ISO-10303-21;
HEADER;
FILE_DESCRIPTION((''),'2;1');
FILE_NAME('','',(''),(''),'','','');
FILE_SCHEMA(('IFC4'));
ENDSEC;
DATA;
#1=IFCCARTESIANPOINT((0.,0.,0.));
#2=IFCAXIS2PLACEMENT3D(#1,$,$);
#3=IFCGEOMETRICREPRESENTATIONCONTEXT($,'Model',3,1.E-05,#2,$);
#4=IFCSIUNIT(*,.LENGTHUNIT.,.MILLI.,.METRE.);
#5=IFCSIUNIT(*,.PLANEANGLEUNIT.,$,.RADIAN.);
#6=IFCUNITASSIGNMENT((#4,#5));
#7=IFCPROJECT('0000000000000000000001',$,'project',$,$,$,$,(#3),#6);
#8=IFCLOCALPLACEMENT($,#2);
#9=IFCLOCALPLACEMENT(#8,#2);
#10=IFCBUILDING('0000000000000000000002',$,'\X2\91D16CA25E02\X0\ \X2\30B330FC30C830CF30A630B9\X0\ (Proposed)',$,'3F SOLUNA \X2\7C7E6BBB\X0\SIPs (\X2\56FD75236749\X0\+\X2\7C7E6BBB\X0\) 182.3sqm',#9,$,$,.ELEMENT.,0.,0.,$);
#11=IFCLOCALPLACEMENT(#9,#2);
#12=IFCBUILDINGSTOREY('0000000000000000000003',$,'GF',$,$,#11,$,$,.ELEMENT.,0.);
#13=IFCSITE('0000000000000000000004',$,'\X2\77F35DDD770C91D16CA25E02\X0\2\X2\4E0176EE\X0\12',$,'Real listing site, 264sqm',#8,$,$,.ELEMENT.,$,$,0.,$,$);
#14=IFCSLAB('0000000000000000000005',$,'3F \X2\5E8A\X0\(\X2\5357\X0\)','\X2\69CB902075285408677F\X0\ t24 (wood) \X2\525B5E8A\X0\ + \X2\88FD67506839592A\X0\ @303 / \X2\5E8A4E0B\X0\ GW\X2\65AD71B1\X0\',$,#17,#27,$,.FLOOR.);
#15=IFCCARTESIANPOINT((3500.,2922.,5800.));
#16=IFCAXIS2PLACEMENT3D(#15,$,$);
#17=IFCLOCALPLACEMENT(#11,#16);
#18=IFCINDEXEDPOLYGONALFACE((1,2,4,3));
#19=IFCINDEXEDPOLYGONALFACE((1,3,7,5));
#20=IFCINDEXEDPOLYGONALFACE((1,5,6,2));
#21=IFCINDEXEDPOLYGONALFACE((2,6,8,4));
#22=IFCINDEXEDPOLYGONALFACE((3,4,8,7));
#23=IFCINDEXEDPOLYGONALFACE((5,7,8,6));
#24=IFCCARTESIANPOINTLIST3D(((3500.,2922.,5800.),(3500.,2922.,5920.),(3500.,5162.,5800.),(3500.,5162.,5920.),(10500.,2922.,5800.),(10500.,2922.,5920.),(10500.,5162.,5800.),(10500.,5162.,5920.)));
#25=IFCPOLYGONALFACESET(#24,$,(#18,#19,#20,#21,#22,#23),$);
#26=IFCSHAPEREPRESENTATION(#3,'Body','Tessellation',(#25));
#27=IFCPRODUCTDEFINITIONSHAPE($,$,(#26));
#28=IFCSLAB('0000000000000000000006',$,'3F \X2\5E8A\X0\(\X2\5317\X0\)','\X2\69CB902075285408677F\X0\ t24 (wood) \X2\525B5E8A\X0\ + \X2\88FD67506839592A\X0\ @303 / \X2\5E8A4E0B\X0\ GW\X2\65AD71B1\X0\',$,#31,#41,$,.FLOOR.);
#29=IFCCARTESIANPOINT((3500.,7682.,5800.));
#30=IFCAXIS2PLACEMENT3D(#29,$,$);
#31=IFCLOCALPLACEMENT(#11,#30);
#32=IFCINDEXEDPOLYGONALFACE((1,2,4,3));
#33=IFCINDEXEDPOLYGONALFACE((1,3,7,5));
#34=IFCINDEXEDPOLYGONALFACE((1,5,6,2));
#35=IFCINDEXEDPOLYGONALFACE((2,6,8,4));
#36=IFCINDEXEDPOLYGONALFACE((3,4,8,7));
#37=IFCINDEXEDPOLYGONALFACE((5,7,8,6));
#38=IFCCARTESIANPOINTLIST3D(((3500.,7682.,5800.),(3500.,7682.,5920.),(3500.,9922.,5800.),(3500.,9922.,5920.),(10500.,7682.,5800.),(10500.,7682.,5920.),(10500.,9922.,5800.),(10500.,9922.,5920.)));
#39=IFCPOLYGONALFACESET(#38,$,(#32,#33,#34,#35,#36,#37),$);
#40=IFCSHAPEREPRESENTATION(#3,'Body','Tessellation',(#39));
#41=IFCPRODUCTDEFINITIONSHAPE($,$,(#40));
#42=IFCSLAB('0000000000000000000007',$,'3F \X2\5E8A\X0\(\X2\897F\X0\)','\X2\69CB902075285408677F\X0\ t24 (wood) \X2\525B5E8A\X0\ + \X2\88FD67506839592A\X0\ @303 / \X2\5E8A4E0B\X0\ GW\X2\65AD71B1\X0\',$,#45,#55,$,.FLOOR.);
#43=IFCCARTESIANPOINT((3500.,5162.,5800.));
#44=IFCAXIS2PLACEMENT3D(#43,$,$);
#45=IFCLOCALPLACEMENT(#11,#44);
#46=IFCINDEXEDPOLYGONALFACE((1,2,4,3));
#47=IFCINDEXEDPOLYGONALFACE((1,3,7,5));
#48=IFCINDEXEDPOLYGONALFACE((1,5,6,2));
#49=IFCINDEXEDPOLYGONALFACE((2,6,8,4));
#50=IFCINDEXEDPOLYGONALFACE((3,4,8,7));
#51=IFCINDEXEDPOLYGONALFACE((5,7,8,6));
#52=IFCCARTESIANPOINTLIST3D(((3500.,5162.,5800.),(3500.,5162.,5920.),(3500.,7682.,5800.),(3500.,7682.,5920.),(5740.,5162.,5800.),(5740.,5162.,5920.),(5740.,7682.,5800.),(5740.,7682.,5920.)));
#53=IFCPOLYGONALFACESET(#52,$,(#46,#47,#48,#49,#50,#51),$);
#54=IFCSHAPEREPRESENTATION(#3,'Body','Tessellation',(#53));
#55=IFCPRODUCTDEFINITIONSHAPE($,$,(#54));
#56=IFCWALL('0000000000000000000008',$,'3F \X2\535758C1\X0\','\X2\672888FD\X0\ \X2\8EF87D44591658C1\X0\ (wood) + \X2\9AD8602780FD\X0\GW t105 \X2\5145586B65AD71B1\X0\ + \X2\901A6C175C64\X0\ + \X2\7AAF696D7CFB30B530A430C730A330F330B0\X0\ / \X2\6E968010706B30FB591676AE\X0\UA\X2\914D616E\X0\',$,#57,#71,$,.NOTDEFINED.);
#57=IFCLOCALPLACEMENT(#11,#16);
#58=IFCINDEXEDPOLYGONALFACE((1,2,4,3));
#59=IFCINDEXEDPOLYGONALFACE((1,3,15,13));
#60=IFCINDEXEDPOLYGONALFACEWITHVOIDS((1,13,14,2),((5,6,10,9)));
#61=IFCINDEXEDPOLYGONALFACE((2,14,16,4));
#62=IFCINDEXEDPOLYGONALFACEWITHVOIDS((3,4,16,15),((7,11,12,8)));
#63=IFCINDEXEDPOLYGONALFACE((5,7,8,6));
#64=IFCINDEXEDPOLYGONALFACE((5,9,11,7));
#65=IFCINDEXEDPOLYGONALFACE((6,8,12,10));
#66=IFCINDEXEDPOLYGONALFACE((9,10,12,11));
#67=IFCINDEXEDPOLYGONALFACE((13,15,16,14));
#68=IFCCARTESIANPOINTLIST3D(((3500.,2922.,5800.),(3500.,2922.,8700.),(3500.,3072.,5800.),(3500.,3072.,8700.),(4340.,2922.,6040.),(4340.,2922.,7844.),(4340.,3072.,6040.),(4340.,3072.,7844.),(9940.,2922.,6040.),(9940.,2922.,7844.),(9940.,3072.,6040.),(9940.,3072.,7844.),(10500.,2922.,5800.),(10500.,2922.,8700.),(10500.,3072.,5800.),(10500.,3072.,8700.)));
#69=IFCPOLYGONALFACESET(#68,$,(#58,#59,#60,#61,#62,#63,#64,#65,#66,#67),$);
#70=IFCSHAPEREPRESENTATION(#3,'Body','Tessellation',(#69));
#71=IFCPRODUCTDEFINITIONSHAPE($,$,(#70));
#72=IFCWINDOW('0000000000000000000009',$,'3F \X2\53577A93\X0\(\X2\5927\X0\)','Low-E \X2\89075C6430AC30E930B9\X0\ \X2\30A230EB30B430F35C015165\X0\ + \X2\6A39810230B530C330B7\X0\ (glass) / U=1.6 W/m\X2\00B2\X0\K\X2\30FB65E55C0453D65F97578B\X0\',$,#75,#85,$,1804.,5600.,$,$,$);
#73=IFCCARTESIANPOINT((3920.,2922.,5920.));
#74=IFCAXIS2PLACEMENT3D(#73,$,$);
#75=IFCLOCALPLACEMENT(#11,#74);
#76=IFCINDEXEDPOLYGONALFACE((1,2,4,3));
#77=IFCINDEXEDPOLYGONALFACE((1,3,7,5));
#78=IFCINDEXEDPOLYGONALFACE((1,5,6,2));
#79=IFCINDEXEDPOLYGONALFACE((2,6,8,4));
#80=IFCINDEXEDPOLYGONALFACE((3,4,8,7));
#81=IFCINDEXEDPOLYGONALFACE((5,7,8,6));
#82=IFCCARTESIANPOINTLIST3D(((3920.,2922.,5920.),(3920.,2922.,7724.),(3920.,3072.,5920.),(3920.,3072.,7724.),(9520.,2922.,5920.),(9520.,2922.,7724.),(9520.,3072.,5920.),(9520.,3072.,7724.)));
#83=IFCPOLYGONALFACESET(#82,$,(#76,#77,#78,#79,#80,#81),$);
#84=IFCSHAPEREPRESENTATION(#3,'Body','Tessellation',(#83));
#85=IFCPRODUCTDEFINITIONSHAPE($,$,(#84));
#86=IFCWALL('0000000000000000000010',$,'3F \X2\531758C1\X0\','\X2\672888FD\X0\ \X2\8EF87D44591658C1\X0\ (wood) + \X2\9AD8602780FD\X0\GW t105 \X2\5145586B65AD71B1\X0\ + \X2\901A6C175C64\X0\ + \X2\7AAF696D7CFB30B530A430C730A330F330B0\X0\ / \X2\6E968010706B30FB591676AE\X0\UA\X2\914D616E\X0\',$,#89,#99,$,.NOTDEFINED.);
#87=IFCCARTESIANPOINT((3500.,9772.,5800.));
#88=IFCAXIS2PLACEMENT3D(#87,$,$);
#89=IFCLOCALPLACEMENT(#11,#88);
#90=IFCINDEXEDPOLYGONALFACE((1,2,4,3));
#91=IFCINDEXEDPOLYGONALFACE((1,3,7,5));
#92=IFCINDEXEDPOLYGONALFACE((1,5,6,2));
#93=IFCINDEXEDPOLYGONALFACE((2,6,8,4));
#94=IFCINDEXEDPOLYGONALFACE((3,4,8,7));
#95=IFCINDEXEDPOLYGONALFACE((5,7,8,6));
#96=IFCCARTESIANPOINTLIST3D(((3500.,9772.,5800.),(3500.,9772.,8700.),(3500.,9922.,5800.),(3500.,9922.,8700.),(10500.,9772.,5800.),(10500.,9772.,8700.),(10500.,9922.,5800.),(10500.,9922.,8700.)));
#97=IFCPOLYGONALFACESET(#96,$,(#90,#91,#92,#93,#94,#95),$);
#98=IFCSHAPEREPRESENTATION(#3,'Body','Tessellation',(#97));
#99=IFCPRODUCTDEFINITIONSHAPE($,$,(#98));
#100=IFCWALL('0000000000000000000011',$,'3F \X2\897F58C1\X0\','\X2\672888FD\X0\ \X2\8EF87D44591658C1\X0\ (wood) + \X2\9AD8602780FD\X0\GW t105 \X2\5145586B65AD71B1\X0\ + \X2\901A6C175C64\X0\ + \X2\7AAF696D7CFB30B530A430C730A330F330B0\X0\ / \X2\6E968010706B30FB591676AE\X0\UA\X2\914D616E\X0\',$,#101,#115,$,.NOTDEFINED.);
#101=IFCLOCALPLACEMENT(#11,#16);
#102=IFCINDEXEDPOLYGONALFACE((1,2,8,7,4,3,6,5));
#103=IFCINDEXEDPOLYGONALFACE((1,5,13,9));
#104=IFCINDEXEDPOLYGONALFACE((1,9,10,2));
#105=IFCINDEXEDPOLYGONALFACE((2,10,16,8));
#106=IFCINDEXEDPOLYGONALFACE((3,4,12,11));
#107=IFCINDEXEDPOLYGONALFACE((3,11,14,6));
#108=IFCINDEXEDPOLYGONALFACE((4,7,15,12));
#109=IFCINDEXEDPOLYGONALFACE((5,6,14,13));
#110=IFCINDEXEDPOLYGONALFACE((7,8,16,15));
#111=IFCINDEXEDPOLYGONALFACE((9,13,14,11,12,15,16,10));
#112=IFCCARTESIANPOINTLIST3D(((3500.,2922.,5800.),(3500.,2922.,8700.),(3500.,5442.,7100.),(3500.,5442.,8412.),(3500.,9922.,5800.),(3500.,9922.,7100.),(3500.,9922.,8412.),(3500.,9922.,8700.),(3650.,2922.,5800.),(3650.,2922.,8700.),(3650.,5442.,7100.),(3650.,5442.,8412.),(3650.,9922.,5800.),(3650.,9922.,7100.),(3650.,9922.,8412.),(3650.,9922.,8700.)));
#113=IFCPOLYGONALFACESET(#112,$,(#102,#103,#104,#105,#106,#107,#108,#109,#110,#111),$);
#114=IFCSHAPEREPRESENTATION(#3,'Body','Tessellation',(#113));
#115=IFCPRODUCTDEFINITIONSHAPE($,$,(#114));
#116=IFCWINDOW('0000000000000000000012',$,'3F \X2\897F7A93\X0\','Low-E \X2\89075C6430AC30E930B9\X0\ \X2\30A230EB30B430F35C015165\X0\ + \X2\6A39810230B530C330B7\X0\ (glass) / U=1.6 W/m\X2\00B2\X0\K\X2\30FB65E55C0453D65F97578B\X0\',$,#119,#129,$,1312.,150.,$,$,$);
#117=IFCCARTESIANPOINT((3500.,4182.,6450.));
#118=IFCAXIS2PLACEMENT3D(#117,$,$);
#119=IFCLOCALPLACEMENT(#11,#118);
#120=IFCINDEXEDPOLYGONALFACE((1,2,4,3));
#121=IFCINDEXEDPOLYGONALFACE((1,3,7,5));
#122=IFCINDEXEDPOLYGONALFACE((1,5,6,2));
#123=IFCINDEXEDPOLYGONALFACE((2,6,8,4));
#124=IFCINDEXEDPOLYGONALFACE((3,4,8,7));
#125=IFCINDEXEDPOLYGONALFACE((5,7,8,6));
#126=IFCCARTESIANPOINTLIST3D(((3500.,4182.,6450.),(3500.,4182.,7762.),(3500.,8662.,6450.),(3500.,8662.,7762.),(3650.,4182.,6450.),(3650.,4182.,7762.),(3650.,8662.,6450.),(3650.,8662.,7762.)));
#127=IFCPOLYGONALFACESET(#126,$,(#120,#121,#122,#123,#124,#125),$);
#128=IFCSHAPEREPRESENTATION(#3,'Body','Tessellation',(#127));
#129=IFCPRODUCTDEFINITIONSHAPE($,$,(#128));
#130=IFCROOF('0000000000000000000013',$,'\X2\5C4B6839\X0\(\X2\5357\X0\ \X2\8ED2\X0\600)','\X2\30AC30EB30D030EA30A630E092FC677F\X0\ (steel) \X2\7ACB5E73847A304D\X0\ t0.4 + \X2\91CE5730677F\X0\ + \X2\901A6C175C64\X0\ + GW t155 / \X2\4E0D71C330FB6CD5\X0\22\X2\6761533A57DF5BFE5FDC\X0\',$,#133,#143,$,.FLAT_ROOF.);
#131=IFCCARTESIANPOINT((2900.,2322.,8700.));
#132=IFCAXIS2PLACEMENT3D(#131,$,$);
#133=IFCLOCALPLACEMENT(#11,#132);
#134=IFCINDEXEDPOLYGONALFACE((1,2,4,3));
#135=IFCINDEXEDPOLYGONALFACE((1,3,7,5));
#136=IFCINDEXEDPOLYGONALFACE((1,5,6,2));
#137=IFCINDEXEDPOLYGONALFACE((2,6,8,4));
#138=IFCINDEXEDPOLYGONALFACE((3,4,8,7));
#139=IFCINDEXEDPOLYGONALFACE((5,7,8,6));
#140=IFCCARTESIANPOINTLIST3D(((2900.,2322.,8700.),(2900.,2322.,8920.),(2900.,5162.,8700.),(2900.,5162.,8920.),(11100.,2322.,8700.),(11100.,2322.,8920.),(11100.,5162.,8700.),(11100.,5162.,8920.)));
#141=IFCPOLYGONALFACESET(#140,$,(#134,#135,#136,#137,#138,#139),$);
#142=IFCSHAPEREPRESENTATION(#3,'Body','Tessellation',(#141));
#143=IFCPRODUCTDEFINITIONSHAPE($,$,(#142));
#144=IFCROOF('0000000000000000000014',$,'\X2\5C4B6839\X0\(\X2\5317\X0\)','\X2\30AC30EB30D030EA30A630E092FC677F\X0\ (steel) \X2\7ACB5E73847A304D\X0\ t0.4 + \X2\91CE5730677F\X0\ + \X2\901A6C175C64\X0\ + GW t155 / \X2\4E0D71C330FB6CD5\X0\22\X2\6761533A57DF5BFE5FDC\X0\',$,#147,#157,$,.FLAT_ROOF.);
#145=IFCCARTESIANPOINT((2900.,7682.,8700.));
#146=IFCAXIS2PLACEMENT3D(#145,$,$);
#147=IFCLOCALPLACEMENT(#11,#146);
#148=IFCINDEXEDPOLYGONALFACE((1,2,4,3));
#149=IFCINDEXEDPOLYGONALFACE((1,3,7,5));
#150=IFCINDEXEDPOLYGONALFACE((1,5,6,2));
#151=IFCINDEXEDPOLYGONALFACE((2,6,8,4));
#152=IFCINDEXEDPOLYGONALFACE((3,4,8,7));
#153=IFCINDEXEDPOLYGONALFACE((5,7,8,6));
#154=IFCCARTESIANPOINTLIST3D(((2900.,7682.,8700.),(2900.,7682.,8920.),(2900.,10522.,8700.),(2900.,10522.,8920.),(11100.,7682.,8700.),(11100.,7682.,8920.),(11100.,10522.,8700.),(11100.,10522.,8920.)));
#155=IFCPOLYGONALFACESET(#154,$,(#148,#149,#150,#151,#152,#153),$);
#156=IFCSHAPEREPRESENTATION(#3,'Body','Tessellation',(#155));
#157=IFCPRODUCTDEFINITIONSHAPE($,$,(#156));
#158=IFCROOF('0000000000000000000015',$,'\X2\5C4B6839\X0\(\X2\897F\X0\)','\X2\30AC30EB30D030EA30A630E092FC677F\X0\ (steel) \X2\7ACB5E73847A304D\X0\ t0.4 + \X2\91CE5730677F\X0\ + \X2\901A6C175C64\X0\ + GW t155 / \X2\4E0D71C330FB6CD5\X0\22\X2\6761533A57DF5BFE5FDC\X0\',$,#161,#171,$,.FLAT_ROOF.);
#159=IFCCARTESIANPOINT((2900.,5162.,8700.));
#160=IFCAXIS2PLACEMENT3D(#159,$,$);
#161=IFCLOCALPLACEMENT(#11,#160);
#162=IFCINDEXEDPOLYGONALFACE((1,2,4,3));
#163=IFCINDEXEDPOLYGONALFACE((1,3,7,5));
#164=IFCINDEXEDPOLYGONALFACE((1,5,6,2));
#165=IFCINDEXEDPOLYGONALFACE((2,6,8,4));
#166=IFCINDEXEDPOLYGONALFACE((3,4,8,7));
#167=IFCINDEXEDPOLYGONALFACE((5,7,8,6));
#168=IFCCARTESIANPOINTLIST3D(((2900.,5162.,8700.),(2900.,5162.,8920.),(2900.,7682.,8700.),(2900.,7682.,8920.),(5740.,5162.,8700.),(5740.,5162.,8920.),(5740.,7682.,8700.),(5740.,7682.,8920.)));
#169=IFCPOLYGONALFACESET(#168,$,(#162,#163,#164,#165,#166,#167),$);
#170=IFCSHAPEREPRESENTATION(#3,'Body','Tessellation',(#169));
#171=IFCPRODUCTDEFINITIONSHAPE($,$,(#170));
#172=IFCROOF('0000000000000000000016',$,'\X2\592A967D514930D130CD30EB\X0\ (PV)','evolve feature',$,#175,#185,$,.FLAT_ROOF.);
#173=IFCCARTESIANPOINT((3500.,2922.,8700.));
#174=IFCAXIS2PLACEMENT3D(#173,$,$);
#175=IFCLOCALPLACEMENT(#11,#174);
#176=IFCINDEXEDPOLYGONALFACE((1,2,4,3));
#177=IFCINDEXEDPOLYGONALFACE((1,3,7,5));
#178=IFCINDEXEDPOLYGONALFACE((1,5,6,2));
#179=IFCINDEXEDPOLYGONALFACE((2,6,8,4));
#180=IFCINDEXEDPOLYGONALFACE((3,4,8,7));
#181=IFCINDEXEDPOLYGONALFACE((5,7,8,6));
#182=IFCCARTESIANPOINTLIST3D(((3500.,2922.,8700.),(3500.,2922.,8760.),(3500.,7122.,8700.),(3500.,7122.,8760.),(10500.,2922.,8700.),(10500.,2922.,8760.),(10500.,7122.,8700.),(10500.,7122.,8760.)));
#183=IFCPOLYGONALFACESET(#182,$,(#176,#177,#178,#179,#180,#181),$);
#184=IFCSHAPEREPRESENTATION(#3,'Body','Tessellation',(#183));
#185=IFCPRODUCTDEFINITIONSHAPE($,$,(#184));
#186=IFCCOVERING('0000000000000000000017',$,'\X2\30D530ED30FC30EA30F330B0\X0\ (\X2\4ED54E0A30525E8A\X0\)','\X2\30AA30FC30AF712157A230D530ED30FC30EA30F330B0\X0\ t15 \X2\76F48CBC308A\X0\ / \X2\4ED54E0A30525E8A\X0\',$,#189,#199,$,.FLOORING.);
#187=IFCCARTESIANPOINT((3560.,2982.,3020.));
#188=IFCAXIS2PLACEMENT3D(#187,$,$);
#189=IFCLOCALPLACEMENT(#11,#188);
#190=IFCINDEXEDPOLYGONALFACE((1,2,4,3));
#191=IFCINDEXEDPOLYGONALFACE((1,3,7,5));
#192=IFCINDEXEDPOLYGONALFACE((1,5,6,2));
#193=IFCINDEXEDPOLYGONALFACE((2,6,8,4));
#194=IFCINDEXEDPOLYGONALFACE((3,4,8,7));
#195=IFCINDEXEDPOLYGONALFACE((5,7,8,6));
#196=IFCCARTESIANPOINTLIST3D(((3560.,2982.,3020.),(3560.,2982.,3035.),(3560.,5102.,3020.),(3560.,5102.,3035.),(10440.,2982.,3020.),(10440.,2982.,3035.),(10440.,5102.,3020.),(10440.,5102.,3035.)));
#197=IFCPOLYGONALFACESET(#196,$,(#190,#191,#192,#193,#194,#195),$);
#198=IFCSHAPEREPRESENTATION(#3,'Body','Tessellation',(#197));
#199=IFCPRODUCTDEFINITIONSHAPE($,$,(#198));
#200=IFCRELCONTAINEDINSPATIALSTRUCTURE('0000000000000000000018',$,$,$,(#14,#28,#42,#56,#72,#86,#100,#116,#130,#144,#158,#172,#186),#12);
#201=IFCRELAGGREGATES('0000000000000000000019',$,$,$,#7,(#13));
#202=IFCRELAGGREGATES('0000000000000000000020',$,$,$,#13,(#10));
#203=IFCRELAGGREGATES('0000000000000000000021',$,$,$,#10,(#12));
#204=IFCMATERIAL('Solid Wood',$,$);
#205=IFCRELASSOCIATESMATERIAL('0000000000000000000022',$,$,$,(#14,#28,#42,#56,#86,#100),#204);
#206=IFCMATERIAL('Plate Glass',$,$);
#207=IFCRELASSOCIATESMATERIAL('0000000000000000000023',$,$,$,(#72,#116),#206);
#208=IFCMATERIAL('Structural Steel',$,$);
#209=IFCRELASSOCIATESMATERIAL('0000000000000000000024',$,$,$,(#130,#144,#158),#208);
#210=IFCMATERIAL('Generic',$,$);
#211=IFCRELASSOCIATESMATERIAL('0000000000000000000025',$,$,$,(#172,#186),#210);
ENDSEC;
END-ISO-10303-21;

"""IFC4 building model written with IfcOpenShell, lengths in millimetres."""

from ifc_helpers import new_model, si_unit, frame, frame_2d, origin, place, context, project, spatial, rectangle, extrude, material, element, fill, save


model = new_model("IFC4")

# Units and contexts
model_context = context("Model", 3, precision=1e-05, world=origin())
ifc_project = project(units=[si_unit("LENGTHUNIT", "METRE", prefix="MILLI"), si_unit("PLANEANGLEUNIT", "RADIAN")], contexts=[model_context])

# Site, building, storey
site_placement = place(None, origin())
site = spatial("IfcSite", under=ifc_project, at=site_placement, Name="石川県金沢市2丁目12", ObjectType="Real listing site, 264sqm", CompositionType="ELEMENT", RefElevation=0.0)
building_placement = place(site_placement, origin())
building = spatial("IfcBuilding", under=site, at=building_placement, Name="金沢市 コートハウス (Proposed)", ObjectType="3F SOLUNA 籾殻SIPs (国産杉+籾殻) 182.3sqm", CompositionType="ELEMENT", ElevationOfRefHeight=0.0, ElevationOfTerrain=0.0)
storey_placement = place(building_placement, origin())
storey = spatial("IfcBuildingStorey", under=building, at=storey_placement, Name="GF", CompositionType="ELEMENT", Elevation=0.0)

# Slabs
ifc_material_1 = material(Name="Solid Wood")
slab_1_placement = place(storey_placement, frame((3500.0, 2922.0, 5800.0)))
element("IfcSlab", 1, at=slab_1_placement, inside=storey, material=ifc_material_1, Name="3F 床(南)", Description="構造用合板 t24 (wood) 剛床 + 製材根太 @303 / 床下 GW断熱", PredefinedType="FLOOR", context=model_context, shape_type="SweptSolid", body=[
    extrude(rectangle(XDim=7000.0, YDim=2240.0, at=frame_2d((3500.0, 1120.0))), frame((3500.0, 2922.0, 5800.0)), (0.0, 0.0, 1.0), 120.0),
])
slab_2_placement = place(storey_placement, frame((3500.0, 7682.0, 5800.0)))
element("IfcSlab", 2, at=slab_2_placement, inside=storey, material=ifc_material_1, Name="3F 床(北)", Description="構造用合板 t24 (wood) 剛床 + 製材根太 @303 / 床下 GW断熱", PredefinedType="FLOOR", context=model_context, shape_type="SweptSolid", body=[
    extrude(rectangle(XDim=7000.0, YDim=2240.0, at=frame_2d((3500.0, 1120.0))), frame((3500.0, 7682.0, 5800.0)), (0.0, 0.0, 1.0), 120.0),
])
slab_3_placement = place(storey_placement, frame((3500.0, 5162.0, 5800.0)))
element("IfcSlab", 3, at=slab_3_placement, inside=storey, material=ifc_material_1, Name="3F 床(西)", Description="構造用合板 t24 (wood) 剛床 + 製材根太 @303 / 床下 GW断熱", PredefinedType="FLOOR", context=model_context, shape_type="SweptSolid", body=[
    extrude(rectangle(XDim=2240.0, YDim=2520.0, at=frame_2d((1120.0, 1260.0))), frame((3500.0, 5162.0, 5800.0)), (0.0, 0.0, 1.0), 120.0),
])

# Wall, opening, window
wall_1_placement = place(storey_placement, frame((3500.0, 2922.0, 5800.0)))
wall_1 = element("IfcWall", 4, at=wall_1_placement, inside=storey, material=ifc_material_1, Name="3F 南壁", Description="木製 軸組外壁 (wood) + 高性能GW t105 充填断熱 + 通気層 + 窯業系サイディング / 準耐火・外皮UA配慮", PredefinedType="NOTDEFINED", context=model_context, shape_type="SweptSolid", body=[
    extrude(rectangle(XDim=7000.0, YDim=150.0, at=frame_2d((3500.0, 75.0))), frame((3500.0, 2922.0, 5800.0)), (0.0, 0.0, 1.0), 2900.0),
])
opening_1_placement = place(storey_placement, frame((3920.0, 2922.0, 5920.0)))
opening_1 = element("IfcOpeningElement", 5, at=opening_1_placement, cuts=wall_1, PredefinedType="NOTDEFINED", context=model_context, shape_type="SweptSolid", body=[
    extrude(rectangle(XDim=5600.0, YDim=150.0, at=frame_2d((2800.0, 75.0))), frame((3920.0, 2922.0, 5920.0)), (0.0, 0.0, 1.0), 1804.0),
])
ifc_material_2 = material(Name="Plate Glass")
window_1_placement = place(storey_placement, frame((3920.0, 2922.0, 5920.0)))
window_1 = element("IfcWindow", 6, at=window_1_placement, inside=storey, material=ifc_material_2, Name="3F 南窓(大)", Description="Low-E 複層ガラス アルゴン封入 + 樹脂サッシ (glass) / U=1.6 W/m²K・日射取得型", OverallHeight=1804.0, OverallWidth=5600.0, context=model_context, shape_type="SweptSolid", body=[
    extrude(rectangle(XDim=5600.0, YDim=150.0, at=frame_2d((2800.0, 75.0))), frame((3920.0, 2922.0, 5920.0)), (0.0, 0.0, 1.0), 1804.0),
])
fill(opening_1, window_1)

# Wall
wall_2_placement = place(storey_placement, frame((3500.0, 9772.0, 5800.0)))
element("IfcWall", 7, at=wall_2_placement, inside=storey, material=ifc_material_1, Name="3F 北壁", Description="木製 軸組外壁 (wood) + 高性能GW t105 充填断熱 + 通気層 + 窯業系サイディング / 準耐火・外皮UA配慮", PredefinedType="NOTDEFINED", context=model_context, shape_type="SweptSolid", body=[
    extrude(rectangle(XDim=7000.0, YDim=150.0, at=frame_2d((3500.0, 75.0))), frame((3500.0, 9772.0, 5800.0)), (0.0, 0.0, 1.0), 2900.0),
])

# Wall, opening, window
wall_3_placement = place(storey_placement, frame((3500.0, 2922.0, 5800.0)))
wall_3 = element("IfcWall", 8, at=wall_3_placement, inside=storey, material=ifc_material_1, Name="3F 西壁", Description="木製 軸組外壁 (wood) + 高性能GW t105 充填断熱 + 通気層 + 窯業系サイディング / 準耐火・外皮UA配慮", PredefinedType="NOTDEFINED", context=model_context, shape_type="SweptSolid", body=[
    extrude(rectangle(XDim=150.0, YDim=7000.0, at=frame_2d((75.0, 3500.0))), frame((3500.0, 2922.0, 5800.0)), (0.0, 0.0, 1.0), 2900.0),
])
opening_2_placement = place(storey_placement, frame((3500.0, 4182.0, 6450.0)))
opening_2 = element("IfcOpeningElement", 9, at=opening_2_placement, cuts=wall_3, PredefinedType="NOTDEFINED", context=model_context, shape_type="SweptSolid", body=[
    extrude(rectangle(XDim=150.0, YDim=4480.0, at=frame_2d((75.0, 2240.0))), frame((3500.0, 4182.0, 6450.0)), (0.0, 0.0, 1.0), 1312.0),
])
window_2_placement = place(storey_placement, frame((3500.0, 4182.0, 6450.0)))
window_2 = element("IfcWindow", 10, at=window_2_placement, inside=storey, material=ifc_material_2, Name="3F 西窓", Description="Low-E 複層ガラス アルゴン封入 + 樹脂サッシ (glass) / U=1.6 W/m²K・日射取得型", OverallHeight=1312.0, OverallWidth=150.0, context=model_context, shape_type="SweptSolid", body=[
    extrude(rectangle(XDim=150.0, YDim=4480.0, at=frame_2d((75.0, 2240.0))), frame((3500.0, 4182.0, 6450.0)), (0.0, 0.0, 1.0), 1312.0),
])
fill(opening_2, window_2)

# Roofs
ifc_material_3 = material(Name="Structural Steel")
roof_1_placement = place(storey_placement, frame((2900.0, 2322.0, 8700.0)))
element("IfcRoof", 11, at=roof_1_placement, inside=storey, material=ifc_material_3, Name="屋根(南 軒600)", Description="ガルバリウム鋼板 (steel) 立平葺き t0.4 + 野地板 + 通気層 + GW t155 / 不燃・法22条区域対応", PredefinedType="FLAT_ROOF", context=model_context, shape_type="SweptSolid", body=[
    extrude(rectangle(XDim=8200.0, YDim=2840.0, at=frame_2d((4100.0, 1420.0))), frame((2900.0, 2322.0, 8700.0)), (0.0, 0.0, 1.0), 220.0),
])
roof_2_placement = place(storey_placement, frame((2900.0, 7682.0, 8700.0)))
element("IfcRoof", 12, at=roof_2_placement, inside=storey, material=ifc_material_3, Name="屋根(北)", Description="ガルバリウム鋼板 (steel) 立平葺き t0.4 + 野地板 + 通気層 + GW t155 / 不燃・法22条区域対応", PredefinedType="FLAT_ROOF", context=model_context, shape_type="SweptSolid", body=[
    extrude(rectangle(XDim=8200.0, YDim=2840.0, at=frame_2d((4100.0, 1420.0))), frame((2900.0, 7682.0, 8700.0)), (0.0, 0.0, 1.0), 220.0),
])
roof_3_placement = place(storey_placement, frame((2900.0, 5162.0, 8700.0)))
element("IfcRoof", 13, at=roof_3_placement, inside=storey, material=ifc_material_3, Name="屋根(西)", Description="ガルバリウム鋼板 (steel) 立平葺き t0.4 + 野地板 + 通気層 + GW t155 / 不燃・法22条区域対応", PredefinedType="FLAT_ROOF", context=model_context, shape_type="SweptSolid", body=[
    extrude(rectangle(XDim=2840.0, YDim=2520.0, at=frame_2d((1420.0, 1260.0))), frame((2900.0, 5162.0, 8700.0)), (0.0, 0.0, 1.0), 220.0),
])
ifc_material_4 = material(Name="Generic")
roof_4_placement = place(storey_placement, frame((3500.0, 2922.0, 8700.0)))
element("IfcRoof", 14, at=roof_4_placement, inside=storey, material=ifc_material_4, Name="太陽光パネル (PV)", Description="evolve feature", PredefinedType="FLAT_ROOF", context=model_context, shape_type="SweptSolid", body=[
    extrude(rectangle(XDim=7000.0, YDim=4200.0, at=frame_2d((3500.0, 2100.0))), frame((3500.0, 2922.0, 8700.0)), (0.0, 0.0, 1.0), 60.0),
])

# Covering
covering_1_placement = place(storey_placement, frame((3560.0, 2982.0, 3020.0)))
element("IfcCovering", 15, at=covering_1_placement, inside=storey, material=ifc_material_4, Name="フローリング (仕上げ床)", Description="オーク無垢フローリング t15 直貼り / 仕上げ床", PredefinedType="FLOORING", context=model_context, shape_type="SweptSolid", body=[
    extrude(rectangle(XDim=6880.0, YDim=2120.0, at=frame_2d((3440.0, 1060.0))), frame((3560.0, 2982.0, 3020.0)), (0.0, 0.0, 1.0), 15.0),
])

save(model, "model.ifc")
